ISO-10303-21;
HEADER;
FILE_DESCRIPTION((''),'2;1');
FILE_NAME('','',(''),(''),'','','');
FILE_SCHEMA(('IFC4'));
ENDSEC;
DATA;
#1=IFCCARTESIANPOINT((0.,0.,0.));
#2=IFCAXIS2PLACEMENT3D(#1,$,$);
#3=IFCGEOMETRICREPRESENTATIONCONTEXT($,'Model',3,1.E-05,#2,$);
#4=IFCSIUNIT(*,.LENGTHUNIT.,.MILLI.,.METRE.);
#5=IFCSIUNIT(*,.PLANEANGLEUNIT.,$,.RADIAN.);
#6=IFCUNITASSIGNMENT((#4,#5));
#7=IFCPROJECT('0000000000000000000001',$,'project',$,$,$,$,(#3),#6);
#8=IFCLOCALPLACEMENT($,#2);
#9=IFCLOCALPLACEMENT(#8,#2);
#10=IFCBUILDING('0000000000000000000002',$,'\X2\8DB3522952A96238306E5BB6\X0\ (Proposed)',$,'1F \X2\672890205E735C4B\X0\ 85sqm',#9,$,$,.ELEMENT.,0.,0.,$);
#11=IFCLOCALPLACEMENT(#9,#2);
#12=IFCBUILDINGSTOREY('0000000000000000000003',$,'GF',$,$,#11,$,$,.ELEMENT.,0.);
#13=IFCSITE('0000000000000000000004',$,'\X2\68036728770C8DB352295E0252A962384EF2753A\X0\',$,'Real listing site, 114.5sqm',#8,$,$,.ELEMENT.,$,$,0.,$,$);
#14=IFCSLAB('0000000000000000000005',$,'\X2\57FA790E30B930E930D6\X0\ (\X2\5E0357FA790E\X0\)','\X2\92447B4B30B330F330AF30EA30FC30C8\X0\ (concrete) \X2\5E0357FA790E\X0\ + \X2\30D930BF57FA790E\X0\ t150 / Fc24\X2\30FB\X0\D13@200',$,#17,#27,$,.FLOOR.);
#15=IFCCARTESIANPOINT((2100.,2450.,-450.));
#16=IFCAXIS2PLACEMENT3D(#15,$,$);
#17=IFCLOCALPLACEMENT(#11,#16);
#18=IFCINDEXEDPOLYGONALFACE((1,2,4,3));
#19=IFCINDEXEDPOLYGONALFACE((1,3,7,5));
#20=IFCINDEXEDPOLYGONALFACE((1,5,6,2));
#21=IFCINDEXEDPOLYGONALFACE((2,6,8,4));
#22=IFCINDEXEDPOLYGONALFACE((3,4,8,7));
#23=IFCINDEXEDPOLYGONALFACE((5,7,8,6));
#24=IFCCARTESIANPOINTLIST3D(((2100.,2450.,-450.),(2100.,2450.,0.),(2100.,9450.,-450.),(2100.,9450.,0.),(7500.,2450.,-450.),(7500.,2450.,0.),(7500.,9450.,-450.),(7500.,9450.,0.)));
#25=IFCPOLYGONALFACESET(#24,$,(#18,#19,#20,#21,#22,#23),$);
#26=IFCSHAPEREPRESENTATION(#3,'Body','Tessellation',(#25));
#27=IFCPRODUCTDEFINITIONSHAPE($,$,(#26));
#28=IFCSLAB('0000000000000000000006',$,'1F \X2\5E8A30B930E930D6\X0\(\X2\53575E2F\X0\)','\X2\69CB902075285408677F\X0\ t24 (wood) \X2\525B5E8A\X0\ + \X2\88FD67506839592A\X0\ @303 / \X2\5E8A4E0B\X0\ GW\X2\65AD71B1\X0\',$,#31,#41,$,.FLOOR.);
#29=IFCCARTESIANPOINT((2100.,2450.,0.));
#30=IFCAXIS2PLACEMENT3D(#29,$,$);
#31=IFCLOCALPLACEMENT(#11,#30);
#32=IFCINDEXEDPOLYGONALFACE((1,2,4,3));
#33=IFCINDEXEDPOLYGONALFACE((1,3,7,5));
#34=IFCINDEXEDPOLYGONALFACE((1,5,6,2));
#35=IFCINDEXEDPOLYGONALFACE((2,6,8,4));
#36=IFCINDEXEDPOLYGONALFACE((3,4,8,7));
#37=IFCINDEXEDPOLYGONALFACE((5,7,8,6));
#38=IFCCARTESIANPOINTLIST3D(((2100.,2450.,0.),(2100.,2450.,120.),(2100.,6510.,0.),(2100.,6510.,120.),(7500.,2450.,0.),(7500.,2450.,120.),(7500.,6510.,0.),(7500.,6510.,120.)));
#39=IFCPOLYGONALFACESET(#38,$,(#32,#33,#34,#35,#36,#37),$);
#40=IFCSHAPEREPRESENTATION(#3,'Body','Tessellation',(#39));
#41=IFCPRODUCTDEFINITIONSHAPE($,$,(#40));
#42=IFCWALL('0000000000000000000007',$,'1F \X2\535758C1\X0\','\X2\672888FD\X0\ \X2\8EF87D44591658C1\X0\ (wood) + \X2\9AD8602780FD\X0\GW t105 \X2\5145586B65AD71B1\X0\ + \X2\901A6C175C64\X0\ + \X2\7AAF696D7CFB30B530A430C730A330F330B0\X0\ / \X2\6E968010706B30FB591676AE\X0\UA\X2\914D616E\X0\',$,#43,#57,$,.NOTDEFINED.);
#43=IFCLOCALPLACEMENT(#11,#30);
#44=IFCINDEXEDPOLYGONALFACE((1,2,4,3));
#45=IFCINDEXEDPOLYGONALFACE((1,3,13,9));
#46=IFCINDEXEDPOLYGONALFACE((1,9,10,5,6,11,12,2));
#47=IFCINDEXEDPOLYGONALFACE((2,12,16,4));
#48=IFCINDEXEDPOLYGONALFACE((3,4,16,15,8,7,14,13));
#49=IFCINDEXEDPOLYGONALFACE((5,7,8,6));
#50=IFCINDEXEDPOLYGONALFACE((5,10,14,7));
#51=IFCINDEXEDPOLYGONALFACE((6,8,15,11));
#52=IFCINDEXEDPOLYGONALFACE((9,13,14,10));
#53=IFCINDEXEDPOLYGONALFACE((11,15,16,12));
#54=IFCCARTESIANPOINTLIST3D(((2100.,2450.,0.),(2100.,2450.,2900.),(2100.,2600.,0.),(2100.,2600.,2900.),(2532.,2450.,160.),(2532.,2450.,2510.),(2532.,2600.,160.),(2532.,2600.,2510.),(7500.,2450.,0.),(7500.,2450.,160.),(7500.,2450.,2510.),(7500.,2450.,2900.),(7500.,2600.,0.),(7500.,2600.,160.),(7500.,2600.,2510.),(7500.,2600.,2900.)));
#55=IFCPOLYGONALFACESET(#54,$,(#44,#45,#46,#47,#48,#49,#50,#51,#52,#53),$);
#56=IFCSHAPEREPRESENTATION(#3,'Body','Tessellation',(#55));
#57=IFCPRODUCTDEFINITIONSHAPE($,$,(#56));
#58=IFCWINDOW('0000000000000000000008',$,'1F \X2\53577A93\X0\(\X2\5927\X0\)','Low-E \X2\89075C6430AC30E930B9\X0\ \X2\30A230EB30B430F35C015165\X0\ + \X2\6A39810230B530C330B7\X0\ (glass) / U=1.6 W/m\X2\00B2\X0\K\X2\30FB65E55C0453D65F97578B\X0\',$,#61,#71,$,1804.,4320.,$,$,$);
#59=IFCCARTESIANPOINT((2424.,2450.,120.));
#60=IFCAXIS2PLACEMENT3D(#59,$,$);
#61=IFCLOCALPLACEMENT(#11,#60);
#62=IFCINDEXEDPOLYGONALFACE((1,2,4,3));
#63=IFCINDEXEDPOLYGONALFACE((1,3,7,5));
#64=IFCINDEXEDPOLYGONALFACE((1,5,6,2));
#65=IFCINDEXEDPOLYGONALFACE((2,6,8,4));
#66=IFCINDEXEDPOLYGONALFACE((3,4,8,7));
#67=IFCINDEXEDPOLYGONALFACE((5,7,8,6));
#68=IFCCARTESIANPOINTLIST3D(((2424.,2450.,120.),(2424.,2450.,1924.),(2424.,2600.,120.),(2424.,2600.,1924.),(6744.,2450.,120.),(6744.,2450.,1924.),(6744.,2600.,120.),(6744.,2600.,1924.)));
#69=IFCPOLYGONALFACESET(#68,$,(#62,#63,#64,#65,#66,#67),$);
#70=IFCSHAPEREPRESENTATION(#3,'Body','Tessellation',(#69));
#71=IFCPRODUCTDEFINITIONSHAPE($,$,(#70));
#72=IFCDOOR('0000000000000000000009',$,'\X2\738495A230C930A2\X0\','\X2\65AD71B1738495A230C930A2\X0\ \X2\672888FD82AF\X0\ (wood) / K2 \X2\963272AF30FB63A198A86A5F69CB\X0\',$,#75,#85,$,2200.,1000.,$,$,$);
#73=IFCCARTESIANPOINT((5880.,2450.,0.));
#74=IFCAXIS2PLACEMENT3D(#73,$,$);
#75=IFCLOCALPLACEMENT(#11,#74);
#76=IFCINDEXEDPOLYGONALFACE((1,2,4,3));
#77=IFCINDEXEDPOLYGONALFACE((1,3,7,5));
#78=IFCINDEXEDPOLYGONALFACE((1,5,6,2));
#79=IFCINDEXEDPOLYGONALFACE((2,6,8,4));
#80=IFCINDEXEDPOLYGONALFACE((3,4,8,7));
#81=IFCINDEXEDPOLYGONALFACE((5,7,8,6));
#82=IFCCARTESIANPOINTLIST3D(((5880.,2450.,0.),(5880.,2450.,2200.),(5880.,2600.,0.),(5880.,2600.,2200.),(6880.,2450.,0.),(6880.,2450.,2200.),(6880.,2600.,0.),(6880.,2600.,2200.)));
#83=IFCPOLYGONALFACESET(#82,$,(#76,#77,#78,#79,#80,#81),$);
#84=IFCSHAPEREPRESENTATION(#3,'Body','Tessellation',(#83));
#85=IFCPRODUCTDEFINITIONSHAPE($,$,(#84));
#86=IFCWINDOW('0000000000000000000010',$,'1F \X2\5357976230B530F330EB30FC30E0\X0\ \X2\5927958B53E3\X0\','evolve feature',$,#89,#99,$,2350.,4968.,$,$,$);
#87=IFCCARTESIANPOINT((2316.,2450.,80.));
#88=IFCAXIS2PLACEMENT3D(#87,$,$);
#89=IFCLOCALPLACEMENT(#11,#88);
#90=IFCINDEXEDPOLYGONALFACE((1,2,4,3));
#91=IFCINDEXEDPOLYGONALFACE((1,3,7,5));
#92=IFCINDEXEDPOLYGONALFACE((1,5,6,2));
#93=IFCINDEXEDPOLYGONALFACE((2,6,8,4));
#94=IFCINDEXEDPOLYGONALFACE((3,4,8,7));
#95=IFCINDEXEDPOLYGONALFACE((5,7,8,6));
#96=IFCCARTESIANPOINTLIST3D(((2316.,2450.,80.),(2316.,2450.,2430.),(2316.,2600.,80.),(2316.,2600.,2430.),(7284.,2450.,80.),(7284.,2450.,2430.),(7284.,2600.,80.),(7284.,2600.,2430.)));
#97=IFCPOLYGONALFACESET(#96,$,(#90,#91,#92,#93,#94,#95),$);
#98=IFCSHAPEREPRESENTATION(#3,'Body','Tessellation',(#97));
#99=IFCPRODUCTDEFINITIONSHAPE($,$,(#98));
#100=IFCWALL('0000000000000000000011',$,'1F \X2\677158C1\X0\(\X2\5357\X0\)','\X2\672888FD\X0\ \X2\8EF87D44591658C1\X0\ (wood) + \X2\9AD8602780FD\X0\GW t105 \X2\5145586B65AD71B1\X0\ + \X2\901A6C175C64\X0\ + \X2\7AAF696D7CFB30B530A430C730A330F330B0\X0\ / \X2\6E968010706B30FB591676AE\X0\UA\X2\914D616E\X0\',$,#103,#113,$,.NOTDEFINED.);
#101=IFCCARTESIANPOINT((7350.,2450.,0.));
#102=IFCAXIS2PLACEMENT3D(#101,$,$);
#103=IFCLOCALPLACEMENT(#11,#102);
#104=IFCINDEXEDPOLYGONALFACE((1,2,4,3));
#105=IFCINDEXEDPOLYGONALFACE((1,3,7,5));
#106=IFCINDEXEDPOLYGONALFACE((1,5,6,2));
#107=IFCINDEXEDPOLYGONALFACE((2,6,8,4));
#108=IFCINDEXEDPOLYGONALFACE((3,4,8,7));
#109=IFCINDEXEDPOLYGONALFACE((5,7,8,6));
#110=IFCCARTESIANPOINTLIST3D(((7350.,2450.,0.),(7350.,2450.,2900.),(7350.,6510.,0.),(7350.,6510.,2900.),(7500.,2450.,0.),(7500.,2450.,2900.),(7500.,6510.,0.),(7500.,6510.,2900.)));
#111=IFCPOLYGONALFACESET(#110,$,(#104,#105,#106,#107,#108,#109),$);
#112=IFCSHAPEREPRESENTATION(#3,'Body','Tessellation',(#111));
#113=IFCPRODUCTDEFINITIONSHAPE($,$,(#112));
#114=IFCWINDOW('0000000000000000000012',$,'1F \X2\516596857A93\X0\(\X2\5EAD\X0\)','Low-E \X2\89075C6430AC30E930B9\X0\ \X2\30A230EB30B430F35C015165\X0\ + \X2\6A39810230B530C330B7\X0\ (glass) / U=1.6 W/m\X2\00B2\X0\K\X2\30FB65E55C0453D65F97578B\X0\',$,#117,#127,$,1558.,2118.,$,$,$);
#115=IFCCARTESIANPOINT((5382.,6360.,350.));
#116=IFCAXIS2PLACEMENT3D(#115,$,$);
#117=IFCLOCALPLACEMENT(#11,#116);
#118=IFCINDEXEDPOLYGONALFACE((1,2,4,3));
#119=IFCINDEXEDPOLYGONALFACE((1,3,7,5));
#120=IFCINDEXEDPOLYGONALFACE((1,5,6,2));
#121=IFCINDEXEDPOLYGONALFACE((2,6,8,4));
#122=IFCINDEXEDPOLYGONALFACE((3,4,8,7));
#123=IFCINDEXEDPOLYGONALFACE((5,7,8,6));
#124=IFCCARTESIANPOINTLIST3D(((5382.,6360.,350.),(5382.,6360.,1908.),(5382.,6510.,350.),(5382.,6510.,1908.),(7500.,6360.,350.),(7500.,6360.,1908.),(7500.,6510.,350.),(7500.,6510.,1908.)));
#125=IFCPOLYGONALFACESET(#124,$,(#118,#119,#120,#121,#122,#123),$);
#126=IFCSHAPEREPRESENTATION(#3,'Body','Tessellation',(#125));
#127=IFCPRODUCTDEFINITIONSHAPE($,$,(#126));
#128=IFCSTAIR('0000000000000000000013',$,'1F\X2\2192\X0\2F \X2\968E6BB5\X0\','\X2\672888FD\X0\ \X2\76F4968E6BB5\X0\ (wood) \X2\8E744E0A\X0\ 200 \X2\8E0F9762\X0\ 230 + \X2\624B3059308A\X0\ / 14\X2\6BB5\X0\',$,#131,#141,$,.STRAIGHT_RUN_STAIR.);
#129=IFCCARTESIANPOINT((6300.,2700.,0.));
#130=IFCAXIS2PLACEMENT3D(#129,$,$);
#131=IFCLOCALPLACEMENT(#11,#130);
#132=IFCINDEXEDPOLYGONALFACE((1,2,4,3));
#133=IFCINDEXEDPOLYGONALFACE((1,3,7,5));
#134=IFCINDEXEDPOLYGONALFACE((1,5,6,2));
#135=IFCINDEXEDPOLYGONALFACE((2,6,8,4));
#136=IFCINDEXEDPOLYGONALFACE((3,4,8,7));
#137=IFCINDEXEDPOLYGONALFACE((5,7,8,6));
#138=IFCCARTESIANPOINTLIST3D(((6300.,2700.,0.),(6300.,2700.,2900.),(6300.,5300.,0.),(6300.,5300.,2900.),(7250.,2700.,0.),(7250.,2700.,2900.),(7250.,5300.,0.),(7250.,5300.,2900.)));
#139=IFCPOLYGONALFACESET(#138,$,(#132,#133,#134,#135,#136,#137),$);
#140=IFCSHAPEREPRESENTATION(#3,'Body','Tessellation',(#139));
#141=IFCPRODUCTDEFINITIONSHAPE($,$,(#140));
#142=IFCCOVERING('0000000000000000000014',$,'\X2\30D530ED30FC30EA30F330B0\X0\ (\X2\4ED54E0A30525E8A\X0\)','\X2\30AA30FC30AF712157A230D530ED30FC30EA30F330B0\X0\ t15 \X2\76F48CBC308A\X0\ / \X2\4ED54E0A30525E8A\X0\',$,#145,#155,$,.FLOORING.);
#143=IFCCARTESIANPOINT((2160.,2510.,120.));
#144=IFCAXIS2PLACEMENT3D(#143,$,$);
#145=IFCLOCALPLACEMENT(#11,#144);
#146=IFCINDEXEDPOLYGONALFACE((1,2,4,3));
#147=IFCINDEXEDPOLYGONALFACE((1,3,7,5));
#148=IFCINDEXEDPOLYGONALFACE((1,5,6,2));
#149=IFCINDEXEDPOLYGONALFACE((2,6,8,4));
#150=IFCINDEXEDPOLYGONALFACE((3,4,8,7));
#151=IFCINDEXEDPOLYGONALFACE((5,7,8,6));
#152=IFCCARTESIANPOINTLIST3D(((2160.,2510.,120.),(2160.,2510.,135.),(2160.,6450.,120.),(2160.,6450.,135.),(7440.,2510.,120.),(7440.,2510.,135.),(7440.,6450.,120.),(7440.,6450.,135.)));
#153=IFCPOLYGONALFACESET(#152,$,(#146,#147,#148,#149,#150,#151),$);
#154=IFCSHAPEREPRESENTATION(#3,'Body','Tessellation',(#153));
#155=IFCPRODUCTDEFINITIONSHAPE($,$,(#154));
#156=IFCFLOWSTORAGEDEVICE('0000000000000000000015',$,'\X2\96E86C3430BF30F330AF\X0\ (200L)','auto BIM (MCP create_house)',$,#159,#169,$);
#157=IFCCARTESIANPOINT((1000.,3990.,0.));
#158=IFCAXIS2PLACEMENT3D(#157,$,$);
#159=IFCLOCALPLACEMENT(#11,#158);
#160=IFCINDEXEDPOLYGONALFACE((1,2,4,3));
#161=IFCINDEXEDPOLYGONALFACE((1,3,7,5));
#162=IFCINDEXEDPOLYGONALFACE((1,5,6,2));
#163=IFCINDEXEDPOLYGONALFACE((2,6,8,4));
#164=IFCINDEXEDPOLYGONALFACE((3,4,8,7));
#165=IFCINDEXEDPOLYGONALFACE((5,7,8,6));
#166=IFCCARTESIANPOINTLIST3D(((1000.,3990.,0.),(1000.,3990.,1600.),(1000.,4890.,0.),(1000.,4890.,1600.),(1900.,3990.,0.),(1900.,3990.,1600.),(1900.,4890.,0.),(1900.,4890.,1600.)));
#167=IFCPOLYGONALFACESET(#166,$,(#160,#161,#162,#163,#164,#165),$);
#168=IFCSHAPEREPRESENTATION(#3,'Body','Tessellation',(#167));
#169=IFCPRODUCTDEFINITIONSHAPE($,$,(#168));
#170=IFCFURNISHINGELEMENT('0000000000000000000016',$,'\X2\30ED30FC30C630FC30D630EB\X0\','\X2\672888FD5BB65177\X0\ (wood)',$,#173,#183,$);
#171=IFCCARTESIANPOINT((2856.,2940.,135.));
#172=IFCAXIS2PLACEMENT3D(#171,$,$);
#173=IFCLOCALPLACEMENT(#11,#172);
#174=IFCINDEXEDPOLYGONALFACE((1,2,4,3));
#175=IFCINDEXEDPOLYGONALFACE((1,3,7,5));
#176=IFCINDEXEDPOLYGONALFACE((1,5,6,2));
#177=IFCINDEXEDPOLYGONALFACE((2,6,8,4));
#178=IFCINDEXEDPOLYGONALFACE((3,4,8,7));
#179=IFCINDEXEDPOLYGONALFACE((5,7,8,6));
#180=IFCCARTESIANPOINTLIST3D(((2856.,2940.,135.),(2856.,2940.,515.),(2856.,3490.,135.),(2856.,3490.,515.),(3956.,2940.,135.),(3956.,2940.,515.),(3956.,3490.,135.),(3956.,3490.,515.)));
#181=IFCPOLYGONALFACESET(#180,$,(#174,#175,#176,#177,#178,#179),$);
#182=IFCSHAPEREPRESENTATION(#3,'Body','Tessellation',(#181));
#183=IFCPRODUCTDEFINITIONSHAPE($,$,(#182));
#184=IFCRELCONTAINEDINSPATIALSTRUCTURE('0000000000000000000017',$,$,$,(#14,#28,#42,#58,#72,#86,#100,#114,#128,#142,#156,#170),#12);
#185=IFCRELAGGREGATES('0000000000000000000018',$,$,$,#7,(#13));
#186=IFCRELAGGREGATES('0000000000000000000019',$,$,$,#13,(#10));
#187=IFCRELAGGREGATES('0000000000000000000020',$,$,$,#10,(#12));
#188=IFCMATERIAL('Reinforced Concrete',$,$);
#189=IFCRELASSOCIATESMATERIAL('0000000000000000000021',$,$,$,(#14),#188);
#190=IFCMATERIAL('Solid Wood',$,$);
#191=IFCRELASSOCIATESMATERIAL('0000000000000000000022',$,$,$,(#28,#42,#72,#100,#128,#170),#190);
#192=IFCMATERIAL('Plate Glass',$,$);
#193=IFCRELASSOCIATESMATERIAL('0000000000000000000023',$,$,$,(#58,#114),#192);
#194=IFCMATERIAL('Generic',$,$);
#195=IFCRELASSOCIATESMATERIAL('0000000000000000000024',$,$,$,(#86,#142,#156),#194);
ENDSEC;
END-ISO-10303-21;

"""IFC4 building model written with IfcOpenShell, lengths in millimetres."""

from ifc_helpers import new_model, si_unit, frame, frame_2d, origin, place, context, project, spatial, rectangle, extrude, material, element, fill, save


model = new_model("IFC4")

# Units and contexts
model_context = context("Model", 3, precision=1e-05, world=origin())
ifc_project = project(units=[si_unit("LENGTHUNIT", "METRE", prefix="MILLI"), si_unit("PLANEANGLEUNIT", "RADIAN")], contexts=[model_context])

# Site, building, storey
site_placement = place(None, origin())
site = spatial("IfcSite", under=ifc_project, at=site_placement, Name="栃木県足利市助戸仲町", ObjectType="Real listing site, 114.5sqm", CompositionType="ELEMENT", RefElevation=0.0)
building_placement = place(site_placement, origin())
building = spatial("IfcBuilding", under=site, at=building_placement, Name="足利助戸の家 (Proposed)", ObjectType="1F 木造平屋 85sqm", CompositionType="ELEMENT", ElevationOfRefHeight=0.0, ElevationOfTerrain=0.0)
storey_placement = place(building_placement, origin())
storey = spatial("IfcBuildingStorey", under=building, at=storey_placement, Name="GF", CompositionType="ELEMENT", Elevation=0.0)

# Slabs
ifc_material_1 = material(Name="Reinforced Concrete")
slab_1_placement = place(storey_placement, frame((2100.0, 2450.0, -450.0)))
element("IfcSlab", 1, at=slab_1_placement, inside=storey, material=ifc_material_1, Name="基礎スラブ (布基礎)", Description="鉄筋コンクリート (concrete) 布基礎 + ベタ基礎 t150 / Fc24・D13@200", PredefinedType="FLOOR", context=model_context, shape_type="SweptSolid", body=[
    extrude(rectangle(XDim=5400.0, YDim=7000.0, at=frame_2d((2700.0, 3500.0))), frame((2100.0, 2450.0, -450.0)), (0.0, 0.0, 1.0), 450.0),
])
ifc_material_2 = material(Name="Solid Wood")
slab_2_placement = place(storey_placement, frame((2100.0, 2450.0, 0.0)))
element("IfcSlab", 2, at=slab_2_placement, inside=storey, material=ifc_material_2, Name="1F 床スラブ(南帯)", Description="構造用合板 t24 (wood) 剛床 + 製材根太 @303 / 床下 GW断熱", PredefinedType="FLOOR", context=model_context, shape_type="SweptSolid", body=[
    extrude(rectangle(XDim=5400.0, YDim=4060.0, at=frame_2d((2700.0, 2030.0))), frame((2100.0, 2450.0, 0.0)), (0.0, 0.0, 1.0), 120.0),
])

# Wall, openings, windows, door
wall_1_placement = place(storey_placement, frame((2100.0, 2450.0, 0.0)))
wall_1 = element("IfcWall", 3, at=wall_1_placement, inside=storey, material=ifc_material_2, Name="1F 南壁", Description="木製 軸組外壁 (wood) + 高性能GW t105 充填断熱 + 通気層 + 窯業系サイディング / 準耐火・外皮UA配慮", PredefinedType="NOTDEFINED", context=model_context, shape_type="SweptSolid", body=[
    extrude(rectangle(XDim=5400.0, YDim=150.0, at=frame_2d((2700.0, 75.0))), frame((2100.0, 2450.0, 0.0)), (0.0, 0.0, 1.0), 2900.0),
])
opening_1_placement = place(storey_placement, frame((2424.0, 2450.0, 120.0)))
opening_1 = element("IfcOpeningElement", 4, at=opening_1_placement, cuts=wall_1, PredefinedType="NOTDEFINED", context=model_context, shape_type="SweptSolid", body=[
    extrude(rectangle(XDim=4320.0, YDim=150.0, at=frame_2d((2160.0, 75.0))), frame((2424.0, 2450.0, 120.0)), (0.0, 0.0, 1.0), 1804.0),
])
opening_2_placement = place(storey_placement, frame((5880.0, 2450.0, 0.0)))
opening_2 = element("IfcOpeningElement", 5, at=opening_2_placement, cuts=wall_1, PredefinedType="NOTDEFINED", context=model_context, shape_type="SweptSolid", body=[
    extrude(rectangle(XDim=1000.0, YDim=150.0, at=frame_2d((500.0, 75.0))), frame((5880.0, 2450.0, 0.0)), (0.0, 0.0, 1.0), 2200.0),
])
opening_3_placement = place(storey_placement, frame((2316.0, 2450.0, 80.0)))
opening_3 = element("IfcOpeningElement", 6, at=opening_3_placement, cuts=wall_1, PredefinedType="NOTDEFINED", context=model_context, shape_type="SweptSolid", body=[
    extrude(rectangle(XDim=4968.0, YDim=150.0, at=frame_2d((2484.0, 75.0))), frame((2316.0, 2450.0, 80.0)), (0.0, 0.0, 1.0), 2350.0),
])
ifc_material_3 = material(Name="Plate Glass")
window_1_placement = place(storey_placement, frame((2424.0, 2450.0, 120.0)))
window_1 = element("IfcWindow", 7, at=window_1_placement, inside=storey, material=ifc_material_3, Name="1F 南窓(大)", Description="Low-E 複層ガラス アルゴン封入 + 樹脂サッシ (glass) / U=1.6 W/m²K・日射取得型", OverallHeight=1804.0, OverallWidth=4320.0, context=model_context, shape_type="SweptSolid", body=[
    extrude(rectangle(XDim=4320.0, YDim=150.0, at=frame_2d((2160.0, 75.0))), frame((2424.0, 2450.0, 120.0)), (0.0, 0.0, 1.0), 1804.0),
])
fill(opening_1, window_1)
door_1_placement = place(storey_placement, frame((5880.0, 2450.0, 0.0)))
door_1 = element("IfcDoor", 8, at=door_1_placement, inside=storey, material=ifc_material_2, Name="玄関ドア", Description="断熱玄関ドア 木製芯 (wood) / K2 防犯・採風機構", OverallHeight=2200.0, OverallWidth=1000.0, context=model_context, shape_type="SweptSolid", body=[
    extrude(rectangle(XDim=1000.0, YDim=150.0, at=frame_2d((500.0, 75.0))), frame((5880.0, 2450.0, 0.0)), (0.0, 0.0, 1.0), 2200.0),
])
fill(opening_2, door_1)
ifc_material_4 = material(Name="Generic")
window_2_placement = place(storey_placement, frame((2316.0, 2450.0, 80.0)))
window_2 = element("IfcWindow", 9, at=window_2_placement, inside=storey, material=ifc_material_4, Name="1F 南面サンルーム 大開口", Description="evolve feature", OverallHeight=2350.0, OverallWidth=4968.0, context=model_context, shape_type="SweptSolid", body=[
    extrude(rectangle(XDim=4968.0, YDim=150.0, at=frame_2d((2484.0, 75.0))), frame((2316.0, 2450.0, 80.0)), (0.0, 0.0, 1.0), 2350.0),
])
fill(opening_3, window_2)

# Wall, opening, window
wall_2_placement = place(storey_placement, frame((7350.0, 2450.0, 0.0)))
wall_2 = element("IfcWall", 10, at=wall_2_placement, inside=storey, material=ifc_material_2, Name="1F 東壁(南)", Description="木製 軸組外壁 (wood) + 高性能GW t105 充填断熱 + 通気層 + 窯業系サイディング / 準耐火・外皮UA配慮", PredefinedType="NOTDEFINED", context=model_context, shape_type="SweptSolid", body=[
    extrude(rectangle(XDim=150.0, YDim=4060.0, at=frame_2d((75.0, 2030.0))), frame((7350.0, 2450.0, 0.0)), (0.0, 0.0, 1.0), 2900.0),
])
opening_4_placement = place(storey_placement, frame((5382.0, 6360.0, 350.0)))
opening_4 = element("IfcOpeningElement", 11, at=opening_4_placement, cuts=wall_2, PredefinedType="NOTDEFINED", context=model_context, shape_type="SweptSolid", body=[
    extrude(rectangle(XDim=2118.0, YDim=150.0, at=frame_2d((1059.0, 75.0))), frame((5382.0, 6360.0, 350.0)), (0.0, 0.0, 1.0), 1558.0),
])
window_3_placement = place(storey_placement, frame((5382.0, 6360.0, 350.0)))
window_3 = element("IfcWindow", 12, at=window_3_placement, inside=storey, material=ifc_material_3, Name="1F 入隅窓(庭)", Description="Low-E 複層ガラス アルゴン封入 + 樹脂サッシ (glass) / U=1.6 W/m²K・日射取得型", OverallHeight=1558.0, OverallWidth=2118.0, context=model_context, shape_type="SweptSolid", body=[
    extrude(rectangle(XDim=2118.0, YDim=150.0, at=frame_2d((1059.0, 75.0))), frame((5382.0, 6360.0, 350.0)), (0.0, 0.0, 1.0), 1558.0),
])
fill(opening_4, window_3)

# Stair
stair_placement = place(storey_placement, frame((6300.0, 2700.0, 0.0)))
element("IfcStair", 13, at=stair_placement, inside=storey, material=ifc_material_2, Name="1F→2F 階段", Description="木製 直階段 (wood) 蹴上 200 踏面 230 + 手すり / 14段", PredefinedType="STRAIGHT_RUN_STAIR", context=model_context, shape_type="SweptSolid", body=[
    extrude(rectangle(XDim=950.0, YDim=2600.0, at=frame_2d((475.0, 1300.0))), frame((6300.0, 2700.0, 0.0)), (0.0, 0.0, 1.0), 2900.0),
])

# Covering
covering_placement = place(storey_placement, frame((2160.0, 2510.0, 120.0)))
element("IfcCovering", 14, at=covering_placement, inside=storey, material=ifc_material_4, Name="フローリング (仕上げ床)", Description="オーク無垢フローリング t15 直貼り / 仕上げ床", PredefinedType="FLOORING", context=model_context, shape_type="SweptSolid", body=[
    extrude(rectangle(XDim=5280.0, YDim=3940.0, at=frame_2d((2640.0, 1970.0))), frame((2160.0, 2510.0, 120.0)), (0.0, 0.0, 1.0), 15.0),
])

# Flow storage device
flow_storage_device_placement = place(storey_placement, frame((1000.0, 3990.0, 0.0)))
element("IfcFlowStorageDevice", 15, at=flow_storage_device_placement, inside=storey, material=ifc_material_4, Name="雨水タンク (200L)", Description="auto BIM (MCP create_house)", context=model_context, shape_type="SweptSolid", body=[
    extrude(rectangle(XDim=900.0, YDim=900.0, at=frame_2d((450.0, 450.0))), frame((1000.0, 3990.0, 0.0)), (0.0, 0.0, 1.0), 1600.0),
])

# Furnishing element
furnishing_1_placement = place(storey_placement, frame((2856.0, 2940.0, 135.0)))
element("IfcFurnishingElement", 16, at=furnishing_1_placement, inside=storey, material=ifc_material_2, Name="ローテーブル", Description="木製家具 (wood)", context=model_context, shape_type="SweptSolid", body=[
    extrude(rectangle(XDim=1100.0, YDim=550.0, at=frame_2d((550.0, 275.0))), frame((2856.0, 2940.0, 135.0)), (0.0, 0.0, 1.0), 380.0),
])

save(model, "model.ifc")
